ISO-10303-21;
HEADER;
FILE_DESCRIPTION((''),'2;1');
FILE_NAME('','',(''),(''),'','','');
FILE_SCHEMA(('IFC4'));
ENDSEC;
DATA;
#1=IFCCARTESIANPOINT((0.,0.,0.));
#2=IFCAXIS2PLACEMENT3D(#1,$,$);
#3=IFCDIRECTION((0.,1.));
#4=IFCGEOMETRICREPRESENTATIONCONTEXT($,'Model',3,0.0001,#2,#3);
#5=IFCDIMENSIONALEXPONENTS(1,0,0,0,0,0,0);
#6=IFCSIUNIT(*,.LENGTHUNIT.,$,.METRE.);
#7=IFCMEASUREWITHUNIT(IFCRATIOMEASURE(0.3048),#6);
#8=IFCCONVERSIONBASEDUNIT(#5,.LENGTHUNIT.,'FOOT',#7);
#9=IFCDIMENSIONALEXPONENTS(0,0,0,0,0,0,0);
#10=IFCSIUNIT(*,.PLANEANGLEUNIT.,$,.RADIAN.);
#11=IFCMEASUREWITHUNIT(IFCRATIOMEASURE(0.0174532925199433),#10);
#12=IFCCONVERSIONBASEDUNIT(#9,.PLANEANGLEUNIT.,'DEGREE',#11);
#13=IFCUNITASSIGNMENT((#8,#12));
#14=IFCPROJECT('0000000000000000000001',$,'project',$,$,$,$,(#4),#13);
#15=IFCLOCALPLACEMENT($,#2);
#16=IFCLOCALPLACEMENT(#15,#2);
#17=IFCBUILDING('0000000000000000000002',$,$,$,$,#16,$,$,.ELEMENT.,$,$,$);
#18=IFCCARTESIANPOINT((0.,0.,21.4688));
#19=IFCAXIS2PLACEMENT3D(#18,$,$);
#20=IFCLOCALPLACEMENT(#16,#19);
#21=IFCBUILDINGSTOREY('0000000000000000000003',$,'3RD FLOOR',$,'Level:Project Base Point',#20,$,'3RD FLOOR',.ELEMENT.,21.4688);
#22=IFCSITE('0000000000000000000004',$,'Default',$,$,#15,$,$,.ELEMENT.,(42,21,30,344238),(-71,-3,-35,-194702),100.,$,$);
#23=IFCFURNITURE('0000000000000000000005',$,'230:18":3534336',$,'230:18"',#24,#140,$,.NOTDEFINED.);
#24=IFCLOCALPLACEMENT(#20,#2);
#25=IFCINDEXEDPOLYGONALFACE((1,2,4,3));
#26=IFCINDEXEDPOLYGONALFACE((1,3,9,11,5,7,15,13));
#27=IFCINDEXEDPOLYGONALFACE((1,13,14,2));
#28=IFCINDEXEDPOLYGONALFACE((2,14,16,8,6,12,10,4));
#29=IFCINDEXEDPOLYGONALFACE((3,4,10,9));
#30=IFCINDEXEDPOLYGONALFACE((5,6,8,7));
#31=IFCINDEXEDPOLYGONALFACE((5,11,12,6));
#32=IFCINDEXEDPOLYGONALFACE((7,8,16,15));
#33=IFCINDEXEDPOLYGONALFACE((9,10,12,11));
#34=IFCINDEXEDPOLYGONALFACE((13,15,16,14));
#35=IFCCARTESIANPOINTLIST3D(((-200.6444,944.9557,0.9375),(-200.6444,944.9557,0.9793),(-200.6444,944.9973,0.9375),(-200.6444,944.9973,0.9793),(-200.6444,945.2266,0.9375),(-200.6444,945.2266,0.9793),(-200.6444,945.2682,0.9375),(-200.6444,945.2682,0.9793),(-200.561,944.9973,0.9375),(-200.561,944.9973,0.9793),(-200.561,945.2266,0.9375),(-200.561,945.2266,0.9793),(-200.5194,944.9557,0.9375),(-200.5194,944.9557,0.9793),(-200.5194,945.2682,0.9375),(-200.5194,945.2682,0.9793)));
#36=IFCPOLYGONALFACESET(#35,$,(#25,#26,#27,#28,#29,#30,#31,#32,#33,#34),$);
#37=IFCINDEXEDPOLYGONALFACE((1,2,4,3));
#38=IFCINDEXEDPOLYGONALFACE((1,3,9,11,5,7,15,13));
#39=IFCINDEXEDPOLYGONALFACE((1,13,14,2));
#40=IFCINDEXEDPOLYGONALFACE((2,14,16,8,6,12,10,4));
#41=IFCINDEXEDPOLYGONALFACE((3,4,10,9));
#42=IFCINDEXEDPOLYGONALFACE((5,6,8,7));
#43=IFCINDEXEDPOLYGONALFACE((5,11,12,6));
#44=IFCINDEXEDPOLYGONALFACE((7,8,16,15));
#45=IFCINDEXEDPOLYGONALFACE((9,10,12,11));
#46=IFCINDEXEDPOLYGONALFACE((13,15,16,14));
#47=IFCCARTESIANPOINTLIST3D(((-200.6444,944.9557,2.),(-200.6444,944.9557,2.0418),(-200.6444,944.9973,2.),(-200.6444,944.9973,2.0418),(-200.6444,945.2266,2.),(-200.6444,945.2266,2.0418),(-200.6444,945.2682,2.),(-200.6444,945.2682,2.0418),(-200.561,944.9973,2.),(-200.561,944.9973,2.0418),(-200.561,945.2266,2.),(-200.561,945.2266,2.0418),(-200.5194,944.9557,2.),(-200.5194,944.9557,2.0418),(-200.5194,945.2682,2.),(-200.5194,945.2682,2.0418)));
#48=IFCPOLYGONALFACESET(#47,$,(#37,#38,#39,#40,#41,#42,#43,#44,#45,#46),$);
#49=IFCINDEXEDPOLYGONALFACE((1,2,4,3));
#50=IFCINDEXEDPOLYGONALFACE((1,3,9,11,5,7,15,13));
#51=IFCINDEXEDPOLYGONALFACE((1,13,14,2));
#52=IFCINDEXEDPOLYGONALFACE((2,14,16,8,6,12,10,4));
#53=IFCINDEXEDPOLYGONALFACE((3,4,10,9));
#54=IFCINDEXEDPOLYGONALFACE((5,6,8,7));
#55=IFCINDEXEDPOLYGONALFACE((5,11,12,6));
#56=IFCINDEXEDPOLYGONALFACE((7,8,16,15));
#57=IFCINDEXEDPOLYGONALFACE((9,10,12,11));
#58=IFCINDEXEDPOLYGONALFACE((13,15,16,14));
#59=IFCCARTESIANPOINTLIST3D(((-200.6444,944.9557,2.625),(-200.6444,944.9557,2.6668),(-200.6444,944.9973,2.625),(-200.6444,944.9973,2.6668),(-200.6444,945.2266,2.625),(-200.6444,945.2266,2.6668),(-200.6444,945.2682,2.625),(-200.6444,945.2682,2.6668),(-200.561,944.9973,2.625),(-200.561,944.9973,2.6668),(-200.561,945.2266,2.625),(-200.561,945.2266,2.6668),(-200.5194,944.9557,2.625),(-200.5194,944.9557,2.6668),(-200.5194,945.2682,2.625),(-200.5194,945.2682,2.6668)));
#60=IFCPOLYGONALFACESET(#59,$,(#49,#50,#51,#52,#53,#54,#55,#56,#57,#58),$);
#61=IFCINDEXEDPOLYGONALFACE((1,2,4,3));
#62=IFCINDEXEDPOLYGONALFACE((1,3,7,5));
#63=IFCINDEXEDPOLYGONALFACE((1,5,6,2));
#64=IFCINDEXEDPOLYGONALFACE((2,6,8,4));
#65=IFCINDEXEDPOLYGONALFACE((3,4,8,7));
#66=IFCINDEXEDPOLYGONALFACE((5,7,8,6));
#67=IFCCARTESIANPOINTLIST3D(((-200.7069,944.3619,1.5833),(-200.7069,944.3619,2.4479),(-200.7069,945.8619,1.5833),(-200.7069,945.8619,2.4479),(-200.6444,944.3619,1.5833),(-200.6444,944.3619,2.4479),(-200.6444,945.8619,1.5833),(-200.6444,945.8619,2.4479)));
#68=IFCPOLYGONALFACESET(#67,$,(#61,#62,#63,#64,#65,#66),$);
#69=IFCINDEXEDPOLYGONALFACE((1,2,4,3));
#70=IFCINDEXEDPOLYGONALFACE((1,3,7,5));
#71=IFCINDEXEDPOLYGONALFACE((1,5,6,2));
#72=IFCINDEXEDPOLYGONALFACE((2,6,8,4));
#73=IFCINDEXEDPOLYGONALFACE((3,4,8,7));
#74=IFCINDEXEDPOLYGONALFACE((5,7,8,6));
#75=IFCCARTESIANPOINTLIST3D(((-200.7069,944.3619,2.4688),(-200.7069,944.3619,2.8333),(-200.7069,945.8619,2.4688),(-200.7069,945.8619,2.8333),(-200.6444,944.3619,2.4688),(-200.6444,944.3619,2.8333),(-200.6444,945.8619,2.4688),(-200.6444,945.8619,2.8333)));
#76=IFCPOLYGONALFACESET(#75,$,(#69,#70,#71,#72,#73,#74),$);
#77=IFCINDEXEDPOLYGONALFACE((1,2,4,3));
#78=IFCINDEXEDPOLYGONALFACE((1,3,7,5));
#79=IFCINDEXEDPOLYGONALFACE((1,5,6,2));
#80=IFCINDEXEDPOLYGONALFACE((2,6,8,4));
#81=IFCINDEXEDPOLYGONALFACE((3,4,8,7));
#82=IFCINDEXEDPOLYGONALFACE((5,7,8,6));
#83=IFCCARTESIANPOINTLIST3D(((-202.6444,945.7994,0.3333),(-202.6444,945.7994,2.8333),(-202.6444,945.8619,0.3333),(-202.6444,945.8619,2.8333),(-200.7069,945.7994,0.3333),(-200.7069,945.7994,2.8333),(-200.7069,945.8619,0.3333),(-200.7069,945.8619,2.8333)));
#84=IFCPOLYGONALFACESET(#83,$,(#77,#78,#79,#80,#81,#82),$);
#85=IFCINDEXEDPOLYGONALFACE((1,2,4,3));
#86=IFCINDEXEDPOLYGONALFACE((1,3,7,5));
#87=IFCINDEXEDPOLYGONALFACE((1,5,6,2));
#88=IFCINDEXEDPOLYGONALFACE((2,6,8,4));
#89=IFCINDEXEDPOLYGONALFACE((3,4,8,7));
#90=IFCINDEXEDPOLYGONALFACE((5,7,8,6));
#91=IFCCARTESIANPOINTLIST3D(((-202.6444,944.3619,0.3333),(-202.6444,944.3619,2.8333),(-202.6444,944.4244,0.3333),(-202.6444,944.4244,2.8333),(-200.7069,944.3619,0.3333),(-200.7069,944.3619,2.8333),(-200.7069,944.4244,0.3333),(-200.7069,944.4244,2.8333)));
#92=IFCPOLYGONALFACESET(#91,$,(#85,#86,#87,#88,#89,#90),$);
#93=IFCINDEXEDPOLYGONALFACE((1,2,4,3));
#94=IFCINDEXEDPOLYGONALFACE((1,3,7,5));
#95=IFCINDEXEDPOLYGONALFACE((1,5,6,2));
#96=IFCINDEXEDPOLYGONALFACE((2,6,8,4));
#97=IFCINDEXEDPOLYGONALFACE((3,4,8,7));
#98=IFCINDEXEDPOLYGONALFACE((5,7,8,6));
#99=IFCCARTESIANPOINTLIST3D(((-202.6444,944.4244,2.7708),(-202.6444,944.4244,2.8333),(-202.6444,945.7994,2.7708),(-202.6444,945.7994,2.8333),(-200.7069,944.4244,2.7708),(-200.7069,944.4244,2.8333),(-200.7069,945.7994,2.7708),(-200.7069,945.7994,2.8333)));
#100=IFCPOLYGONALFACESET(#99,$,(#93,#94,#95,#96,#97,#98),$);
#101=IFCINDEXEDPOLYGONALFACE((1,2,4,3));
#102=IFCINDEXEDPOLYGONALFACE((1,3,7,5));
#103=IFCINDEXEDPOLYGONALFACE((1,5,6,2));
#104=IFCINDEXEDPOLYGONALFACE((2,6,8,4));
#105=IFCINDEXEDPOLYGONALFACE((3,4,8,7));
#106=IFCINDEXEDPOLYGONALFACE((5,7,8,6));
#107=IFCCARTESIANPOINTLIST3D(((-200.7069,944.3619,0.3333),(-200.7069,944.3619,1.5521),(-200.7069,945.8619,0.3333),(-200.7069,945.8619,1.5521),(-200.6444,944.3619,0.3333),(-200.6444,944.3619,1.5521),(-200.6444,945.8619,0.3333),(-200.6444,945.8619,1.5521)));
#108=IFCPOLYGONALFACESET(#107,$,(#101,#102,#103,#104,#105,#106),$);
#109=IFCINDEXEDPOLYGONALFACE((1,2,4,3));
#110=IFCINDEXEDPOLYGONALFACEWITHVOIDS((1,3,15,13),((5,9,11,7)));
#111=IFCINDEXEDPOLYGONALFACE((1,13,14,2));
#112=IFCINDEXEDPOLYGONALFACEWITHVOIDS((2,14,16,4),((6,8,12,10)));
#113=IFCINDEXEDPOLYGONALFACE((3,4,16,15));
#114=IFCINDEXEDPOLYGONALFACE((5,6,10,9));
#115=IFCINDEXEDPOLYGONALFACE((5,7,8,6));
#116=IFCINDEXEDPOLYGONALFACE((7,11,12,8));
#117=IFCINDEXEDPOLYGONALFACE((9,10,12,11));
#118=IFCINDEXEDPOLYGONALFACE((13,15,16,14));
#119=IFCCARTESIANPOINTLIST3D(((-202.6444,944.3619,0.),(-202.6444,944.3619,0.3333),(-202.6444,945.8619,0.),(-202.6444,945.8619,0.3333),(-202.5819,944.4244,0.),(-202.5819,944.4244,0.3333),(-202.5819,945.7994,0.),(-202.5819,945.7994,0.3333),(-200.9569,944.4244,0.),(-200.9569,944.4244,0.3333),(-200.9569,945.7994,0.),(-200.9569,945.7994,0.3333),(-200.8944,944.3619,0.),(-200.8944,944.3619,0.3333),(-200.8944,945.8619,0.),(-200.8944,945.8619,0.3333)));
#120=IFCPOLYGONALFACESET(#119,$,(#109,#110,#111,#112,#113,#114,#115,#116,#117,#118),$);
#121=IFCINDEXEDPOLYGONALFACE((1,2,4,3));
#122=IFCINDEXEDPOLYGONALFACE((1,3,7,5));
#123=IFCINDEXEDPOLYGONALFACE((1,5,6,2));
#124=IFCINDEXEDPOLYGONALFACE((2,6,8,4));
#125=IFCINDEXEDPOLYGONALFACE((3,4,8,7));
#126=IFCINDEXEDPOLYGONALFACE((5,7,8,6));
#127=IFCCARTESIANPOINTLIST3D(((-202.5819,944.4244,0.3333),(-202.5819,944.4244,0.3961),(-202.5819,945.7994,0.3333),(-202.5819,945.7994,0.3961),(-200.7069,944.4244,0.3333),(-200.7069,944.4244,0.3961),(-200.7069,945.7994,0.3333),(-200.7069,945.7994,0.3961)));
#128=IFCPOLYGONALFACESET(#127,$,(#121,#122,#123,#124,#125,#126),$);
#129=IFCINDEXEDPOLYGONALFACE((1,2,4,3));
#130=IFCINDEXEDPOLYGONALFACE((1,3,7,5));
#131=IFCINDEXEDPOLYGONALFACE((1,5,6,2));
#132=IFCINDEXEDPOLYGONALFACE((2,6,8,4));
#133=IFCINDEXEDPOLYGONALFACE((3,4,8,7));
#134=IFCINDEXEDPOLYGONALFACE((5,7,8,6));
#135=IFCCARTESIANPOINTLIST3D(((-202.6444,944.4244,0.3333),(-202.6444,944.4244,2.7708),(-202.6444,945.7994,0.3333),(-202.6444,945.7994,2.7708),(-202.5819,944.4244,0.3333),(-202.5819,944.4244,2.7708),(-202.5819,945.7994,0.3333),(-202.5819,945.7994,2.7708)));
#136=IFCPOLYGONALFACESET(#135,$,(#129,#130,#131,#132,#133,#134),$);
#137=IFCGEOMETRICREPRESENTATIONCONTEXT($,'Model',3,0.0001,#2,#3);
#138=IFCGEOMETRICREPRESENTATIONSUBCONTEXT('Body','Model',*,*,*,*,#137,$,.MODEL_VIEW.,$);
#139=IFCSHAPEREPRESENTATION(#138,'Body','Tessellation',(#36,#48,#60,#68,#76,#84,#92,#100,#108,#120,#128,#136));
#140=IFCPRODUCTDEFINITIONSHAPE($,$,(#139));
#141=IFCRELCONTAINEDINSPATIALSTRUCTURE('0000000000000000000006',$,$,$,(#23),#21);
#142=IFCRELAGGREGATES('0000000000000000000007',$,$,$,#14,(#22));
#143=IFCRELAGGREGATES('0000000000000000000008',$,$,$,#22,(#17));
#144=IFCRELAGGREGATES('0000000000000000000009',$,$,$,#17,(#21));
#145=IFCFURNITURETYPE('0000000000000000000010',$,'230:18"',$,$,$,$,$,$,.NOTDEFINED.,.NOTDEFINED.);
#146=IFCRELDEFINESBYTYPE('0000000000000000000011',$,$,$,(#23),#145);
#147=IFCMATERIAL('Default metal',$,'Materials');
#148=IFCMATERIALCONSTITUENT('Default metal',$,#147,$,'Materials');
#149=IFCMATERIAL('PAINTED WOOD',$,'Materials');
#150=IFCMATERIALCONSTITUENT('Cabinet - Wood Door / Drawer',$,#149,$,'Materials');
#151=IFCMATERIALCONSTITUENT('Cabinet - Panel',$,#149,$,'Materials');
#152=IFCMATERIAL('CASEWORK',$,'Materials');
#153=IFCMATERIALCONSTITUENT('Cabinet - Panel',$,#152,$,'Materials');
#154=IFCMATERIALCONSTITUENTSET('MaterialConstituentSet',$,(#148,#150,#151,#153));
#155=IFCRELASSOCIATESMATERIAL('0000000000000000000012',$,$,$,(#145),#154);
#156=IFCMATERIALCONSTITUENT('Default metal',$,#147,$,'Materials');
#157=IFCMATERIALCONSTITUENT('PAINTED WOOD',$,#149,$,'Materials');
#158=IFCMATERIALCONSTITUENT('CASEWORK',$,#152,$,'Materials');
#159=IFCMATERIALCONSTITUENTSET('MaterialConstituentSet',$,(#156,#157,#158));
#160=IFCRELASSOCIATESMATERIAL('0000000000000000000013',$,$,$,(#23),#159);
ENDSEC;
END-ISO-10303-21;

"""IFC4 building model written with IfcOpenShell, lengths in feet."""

from ifc_helpers import new_model, entity, si_unit, converted_unit, direction, frame, frame_2d, origin, origin_2d_with_axis, place, context, subcontext, project, spatial, polyline, rectangle, outline, extrude, source, transform, mapped, material, constituent, constituent_set, type_object, type_shapes, element, save


model = new_model("IFC4")

# Units and contexts
model_context_1 = context("Model", 3, precision=0.0001, world=origin(), true_north=direction((0.0, 1.0)))
model_context_2 = context("Model", 3, precision=0.0001, world=origin(), true_north=direction((0.0, 1.0)))
body_context = subcontext(model_context_2, "Body", "Model", "MODEL_VIEW")
ifc_project = project(units=[converted_unit("LENGTHUNIT", "FOOT", entity("IfcRatioMeasure", 0.3048), si_unit("LENGTHUNIT", "METRE"), dimensions=[1, 0, 0, 0, 0, 0, 0]), converted_unit("PLANEANGLEUNIT", "DEGREE", entity("IfcRatioMeasure", 0.0174532925199433), si_unit("PLANEANGLEUNIT", "RADIAN"), dimensions=[0, 0, 0, 0, 0, 0, 0])], contexts=[model_context_1])

# Site, building, storey
site_placement = place(None, origin())
site = spatial("IfcSite", under=ifc_project, at=site_placement, Name="Default", CompositionType="ELEMENT", RefLatitude=(42, 21, 30, 344238), RefLongitude=(-71, -3, -35, -194702), RefElevation=100.0)
building_placement = place(site_placement, origin())
building = spatial("IfcBuilding", under=site, at=building_placement, CompositionType="ELEMENT")
storey_placement = place(building_placement, frame((0.0, 0.0, 21.4688)))
storey = spatial("IfcBuildingStorey", under=building, at=storey_placement, Name="3RD FLOOR", ObjectType="Level:Project Base Point", LongName="3RD FLOOR", CompositionType="ELEMENT", Elevation=21.4688)

# Furniture
ifc_material_1 = material(Name="CASEWORK", Category="Materials")
ifc_material_2 = material(Name="Default metal", Category="Materials")
ifc_material_3 = material(Name="PAINTED WOOD", Category="Materials")
ifc_constituent_1 = constituent(ifc_material_2, Name="Default metal", Category="Materials")
ifc_constituent_2 = constituent(ifc_material_3, Name="PAINTED WOOD", Category="Materials")
ifc_constituent_3 = constituent(ifc_material_1, Name="CASEWORK", Category="Materials")
ifc_constituent_set_1 = constituent_set(constituents=[ifc_constituent_1, ifc_constituent_2, ifc_constituent_3], Name="MaterialConstituentSet")
ifc_constituent_4 = constituent(ifc_material_2, Name="Default metal", Category="Materials")
ifc_constituent_5 = constituent(ifc_material_3, Name="Cabinet - Wood Door / Drawer", Category="Materials")
ifc_constituent_6 = constituent(ifc_material_3, Name="Cabinet - Panel", Category="Materials")
ifc_constituent_7 = constituent(ifc_material_1, Name="Cabinet - Panel", Category="Materials")
ifc_constituent_set_2 = constituent_set(constituents=[ifc_constituent_4, ifc_constituent_5, ifc_constituent_6, ifc_constituent_7], Name="MaterialConstituentSet")
furniture_type_1 = type_object("IfcFurnitureType", Name="230:18\"", AssemblyPlace="NOTDEFINED", PredefinedType="NOTDEFINED", material=ifc_constituent_set_2)
shared_shape_1 = source(origin(), body_context, "Body", "SweptSolid", [
    extrude(outline(polyline([(-0.1562, -0.0521), (-0.1146, -0.0521), (-0.1146, 0.0313), (0.1146, 0.0313), (0.1146, -0.0521), (0.1562, -0.0521), (0.1562, 0.0729), (-0.1562, 0.0729), (-0.1562, -0.0521)])), frame((0.0615, 2.0521, 0.9375)), (0.0, 0.0, 1.0), 0.0418),
    extrude(outline(polyline([(-0.1562, -0.0521), (-0.1146, -0.0521), (-0.1146, 0.0313), (0.1146, 0.0313), (0.1146, -0.0521), (0.1562, -0.0521), (0.1562, 0.0729), (-0.1562, 0.0729), (-0.1562, -0.0521)])), frame((0.0615, 2.0521, 2.0)), (0.0, 0.0, 1.0), 0.0418),
    extrude(outline(polyline([(-0.1562, -0.0521), (-0.1146, -0.0521), (-0.1146, 0.0313), (0.1146, 0.0313), (0.1146, -0.0521), (0.1562, -0.0521), (0.1562, 0.0729), (-0.1562, 0.0729), (-0.1562, -0.0521)])), frame((0.0615, 2.0521, 2.625)), (0.0, 0.0, 1.0), 0.0418),
    extrude(rectangle(XDim=1.5, YDim=0.0625, at=frame_2d((0.0, 0.0), x_axis=(1.0, 0.0))), frame((0.0615, 1.9688, 1.5833), z_axis=(0.0, 0.0, 1.0), x_axis=(-1.0, 0.0, 0.0)), (0.0, 0.0, 1.0), 0.8646),
    extrude(rectangle(XDim=1.5, YDim=0.0625, at=frame_2d((0.0, 0.0), x_axis=(1.0, 0.0))), frame((0.0615, 1.9688, 2.4688), z_axis=(0.0, 0.0, 1.0), x_axis=(-1.0, 0.0, 0.0)), (0.0, 0.0, 1.0), 0.3646),
    extrude(rectangle(XDim=1.9375, YDim=0.0625, at=frame_2d((0.0, 0.0), x_axis=(1.0, 0.0))), frame((-0.6573, 0.9687, 0.3333), z_axis=(0.0, 0.0, 1.0), x_axis=(0.0, -1.0, 0.0)), (0.0, 0.0, 1.0), 2.5),
    extrude(rectangle(XDim=1.9375, YDim=0.0625, at=frame_2d((0.0, 0.0), x_axis=(1.0, 0.0))), frame((0.7802, 0.9687, 0.3333), z_axis=(0.0, 0.0, 1.0), x_axis=(0.0, -1.0, 0.0)), (0.0, 0.0, 1.0), 2.5),
    extrude(rectangle(XDim=1.9375, YDim=1.375, at=origin_2d_with_axis()), frame((0.0615, 0.9687, 2.7708), z_axis=(0.0, 0.0, 1.0), x_axis=(0.0, 1.0, 0.0)), (0.0, 0.0, 1.0), 0.0625),
    extrude(rectangle(XDim=1.5, YDim=0.0625, at=frame_2d((0.0, 0.0), x_axis=(1.0, 0.0))), frame((0.0615, 1.9688, 0.3333), z_axis=(0.0, 0.0, 1.0), x_axis=(-1.0, 0.0, 0.0)), (0.0, 0.0, 1.0), 1.2187),
    extrude(outline(polyline([(-0.875, -0.75), (0.875, -0.75), (0.875, 0.75), (-0.875, 0.75), (-0.875, -0.75)]), holes=[polyline([(-0.8125, -0.6875), (-0.8125, 0.6875), (0.8125, 0.6875), (0.8125, -0.6875), (-0.8125, -0.6875)])]), frame((0.0615, 0.875, 0.0), z_axis=(0.0, 0.0, 1.0), x_axis=(0.0, -1.0, 0.0)), (0.0, 0.0, 1.0), 0.3333),
    extrude(rectangle(XDim=1.875, YDim=1.375, at=origin_2d_with_axis()), frame((0.0615, 1.0, 0.3333), z_axis=(0.0, 0.0, 1.0), x_axis=(0.0, 1.0, 0.0)), (0.0, 0.0, 1.0), 0.0627),
    extrude(rectangle(XDim=1.375, YDim=0.0625, at=origin_2d_with_axis()), frame((0.0615, 0.0312, 0.3333), z_axis=(0.0, 0.0, 1.0), x_axis=(-1.0, 0.0, 0.0)), (0.0, 0.0, 1.0), 2.4375),
])
type_shapes(furniture_type_1, [shared_shape_1])
furniture_1_placement = place(storey_placement, frame((-202.6444, 945.1734, 0.0), z_axis=(0.0, 0.0, 1.0), x_axis=(0.0, -1.0, 0.0)))
element("IfcFurniture", 1, at=furniture_1_placement, inside=storey, type_object=furniture_type_1, material=ifc_constituent_set_1, Name="230:18\":3534336", ObjectType="230:18\"", PredefinedType="NOTDEFINED", context=body_context, shape_type="MappedRepresentation", body=[
    mapped(shared_shape_1, transform((0.0, 0.0, 0.0), scale=1.0)),
])

save(model, "model.ifc")
